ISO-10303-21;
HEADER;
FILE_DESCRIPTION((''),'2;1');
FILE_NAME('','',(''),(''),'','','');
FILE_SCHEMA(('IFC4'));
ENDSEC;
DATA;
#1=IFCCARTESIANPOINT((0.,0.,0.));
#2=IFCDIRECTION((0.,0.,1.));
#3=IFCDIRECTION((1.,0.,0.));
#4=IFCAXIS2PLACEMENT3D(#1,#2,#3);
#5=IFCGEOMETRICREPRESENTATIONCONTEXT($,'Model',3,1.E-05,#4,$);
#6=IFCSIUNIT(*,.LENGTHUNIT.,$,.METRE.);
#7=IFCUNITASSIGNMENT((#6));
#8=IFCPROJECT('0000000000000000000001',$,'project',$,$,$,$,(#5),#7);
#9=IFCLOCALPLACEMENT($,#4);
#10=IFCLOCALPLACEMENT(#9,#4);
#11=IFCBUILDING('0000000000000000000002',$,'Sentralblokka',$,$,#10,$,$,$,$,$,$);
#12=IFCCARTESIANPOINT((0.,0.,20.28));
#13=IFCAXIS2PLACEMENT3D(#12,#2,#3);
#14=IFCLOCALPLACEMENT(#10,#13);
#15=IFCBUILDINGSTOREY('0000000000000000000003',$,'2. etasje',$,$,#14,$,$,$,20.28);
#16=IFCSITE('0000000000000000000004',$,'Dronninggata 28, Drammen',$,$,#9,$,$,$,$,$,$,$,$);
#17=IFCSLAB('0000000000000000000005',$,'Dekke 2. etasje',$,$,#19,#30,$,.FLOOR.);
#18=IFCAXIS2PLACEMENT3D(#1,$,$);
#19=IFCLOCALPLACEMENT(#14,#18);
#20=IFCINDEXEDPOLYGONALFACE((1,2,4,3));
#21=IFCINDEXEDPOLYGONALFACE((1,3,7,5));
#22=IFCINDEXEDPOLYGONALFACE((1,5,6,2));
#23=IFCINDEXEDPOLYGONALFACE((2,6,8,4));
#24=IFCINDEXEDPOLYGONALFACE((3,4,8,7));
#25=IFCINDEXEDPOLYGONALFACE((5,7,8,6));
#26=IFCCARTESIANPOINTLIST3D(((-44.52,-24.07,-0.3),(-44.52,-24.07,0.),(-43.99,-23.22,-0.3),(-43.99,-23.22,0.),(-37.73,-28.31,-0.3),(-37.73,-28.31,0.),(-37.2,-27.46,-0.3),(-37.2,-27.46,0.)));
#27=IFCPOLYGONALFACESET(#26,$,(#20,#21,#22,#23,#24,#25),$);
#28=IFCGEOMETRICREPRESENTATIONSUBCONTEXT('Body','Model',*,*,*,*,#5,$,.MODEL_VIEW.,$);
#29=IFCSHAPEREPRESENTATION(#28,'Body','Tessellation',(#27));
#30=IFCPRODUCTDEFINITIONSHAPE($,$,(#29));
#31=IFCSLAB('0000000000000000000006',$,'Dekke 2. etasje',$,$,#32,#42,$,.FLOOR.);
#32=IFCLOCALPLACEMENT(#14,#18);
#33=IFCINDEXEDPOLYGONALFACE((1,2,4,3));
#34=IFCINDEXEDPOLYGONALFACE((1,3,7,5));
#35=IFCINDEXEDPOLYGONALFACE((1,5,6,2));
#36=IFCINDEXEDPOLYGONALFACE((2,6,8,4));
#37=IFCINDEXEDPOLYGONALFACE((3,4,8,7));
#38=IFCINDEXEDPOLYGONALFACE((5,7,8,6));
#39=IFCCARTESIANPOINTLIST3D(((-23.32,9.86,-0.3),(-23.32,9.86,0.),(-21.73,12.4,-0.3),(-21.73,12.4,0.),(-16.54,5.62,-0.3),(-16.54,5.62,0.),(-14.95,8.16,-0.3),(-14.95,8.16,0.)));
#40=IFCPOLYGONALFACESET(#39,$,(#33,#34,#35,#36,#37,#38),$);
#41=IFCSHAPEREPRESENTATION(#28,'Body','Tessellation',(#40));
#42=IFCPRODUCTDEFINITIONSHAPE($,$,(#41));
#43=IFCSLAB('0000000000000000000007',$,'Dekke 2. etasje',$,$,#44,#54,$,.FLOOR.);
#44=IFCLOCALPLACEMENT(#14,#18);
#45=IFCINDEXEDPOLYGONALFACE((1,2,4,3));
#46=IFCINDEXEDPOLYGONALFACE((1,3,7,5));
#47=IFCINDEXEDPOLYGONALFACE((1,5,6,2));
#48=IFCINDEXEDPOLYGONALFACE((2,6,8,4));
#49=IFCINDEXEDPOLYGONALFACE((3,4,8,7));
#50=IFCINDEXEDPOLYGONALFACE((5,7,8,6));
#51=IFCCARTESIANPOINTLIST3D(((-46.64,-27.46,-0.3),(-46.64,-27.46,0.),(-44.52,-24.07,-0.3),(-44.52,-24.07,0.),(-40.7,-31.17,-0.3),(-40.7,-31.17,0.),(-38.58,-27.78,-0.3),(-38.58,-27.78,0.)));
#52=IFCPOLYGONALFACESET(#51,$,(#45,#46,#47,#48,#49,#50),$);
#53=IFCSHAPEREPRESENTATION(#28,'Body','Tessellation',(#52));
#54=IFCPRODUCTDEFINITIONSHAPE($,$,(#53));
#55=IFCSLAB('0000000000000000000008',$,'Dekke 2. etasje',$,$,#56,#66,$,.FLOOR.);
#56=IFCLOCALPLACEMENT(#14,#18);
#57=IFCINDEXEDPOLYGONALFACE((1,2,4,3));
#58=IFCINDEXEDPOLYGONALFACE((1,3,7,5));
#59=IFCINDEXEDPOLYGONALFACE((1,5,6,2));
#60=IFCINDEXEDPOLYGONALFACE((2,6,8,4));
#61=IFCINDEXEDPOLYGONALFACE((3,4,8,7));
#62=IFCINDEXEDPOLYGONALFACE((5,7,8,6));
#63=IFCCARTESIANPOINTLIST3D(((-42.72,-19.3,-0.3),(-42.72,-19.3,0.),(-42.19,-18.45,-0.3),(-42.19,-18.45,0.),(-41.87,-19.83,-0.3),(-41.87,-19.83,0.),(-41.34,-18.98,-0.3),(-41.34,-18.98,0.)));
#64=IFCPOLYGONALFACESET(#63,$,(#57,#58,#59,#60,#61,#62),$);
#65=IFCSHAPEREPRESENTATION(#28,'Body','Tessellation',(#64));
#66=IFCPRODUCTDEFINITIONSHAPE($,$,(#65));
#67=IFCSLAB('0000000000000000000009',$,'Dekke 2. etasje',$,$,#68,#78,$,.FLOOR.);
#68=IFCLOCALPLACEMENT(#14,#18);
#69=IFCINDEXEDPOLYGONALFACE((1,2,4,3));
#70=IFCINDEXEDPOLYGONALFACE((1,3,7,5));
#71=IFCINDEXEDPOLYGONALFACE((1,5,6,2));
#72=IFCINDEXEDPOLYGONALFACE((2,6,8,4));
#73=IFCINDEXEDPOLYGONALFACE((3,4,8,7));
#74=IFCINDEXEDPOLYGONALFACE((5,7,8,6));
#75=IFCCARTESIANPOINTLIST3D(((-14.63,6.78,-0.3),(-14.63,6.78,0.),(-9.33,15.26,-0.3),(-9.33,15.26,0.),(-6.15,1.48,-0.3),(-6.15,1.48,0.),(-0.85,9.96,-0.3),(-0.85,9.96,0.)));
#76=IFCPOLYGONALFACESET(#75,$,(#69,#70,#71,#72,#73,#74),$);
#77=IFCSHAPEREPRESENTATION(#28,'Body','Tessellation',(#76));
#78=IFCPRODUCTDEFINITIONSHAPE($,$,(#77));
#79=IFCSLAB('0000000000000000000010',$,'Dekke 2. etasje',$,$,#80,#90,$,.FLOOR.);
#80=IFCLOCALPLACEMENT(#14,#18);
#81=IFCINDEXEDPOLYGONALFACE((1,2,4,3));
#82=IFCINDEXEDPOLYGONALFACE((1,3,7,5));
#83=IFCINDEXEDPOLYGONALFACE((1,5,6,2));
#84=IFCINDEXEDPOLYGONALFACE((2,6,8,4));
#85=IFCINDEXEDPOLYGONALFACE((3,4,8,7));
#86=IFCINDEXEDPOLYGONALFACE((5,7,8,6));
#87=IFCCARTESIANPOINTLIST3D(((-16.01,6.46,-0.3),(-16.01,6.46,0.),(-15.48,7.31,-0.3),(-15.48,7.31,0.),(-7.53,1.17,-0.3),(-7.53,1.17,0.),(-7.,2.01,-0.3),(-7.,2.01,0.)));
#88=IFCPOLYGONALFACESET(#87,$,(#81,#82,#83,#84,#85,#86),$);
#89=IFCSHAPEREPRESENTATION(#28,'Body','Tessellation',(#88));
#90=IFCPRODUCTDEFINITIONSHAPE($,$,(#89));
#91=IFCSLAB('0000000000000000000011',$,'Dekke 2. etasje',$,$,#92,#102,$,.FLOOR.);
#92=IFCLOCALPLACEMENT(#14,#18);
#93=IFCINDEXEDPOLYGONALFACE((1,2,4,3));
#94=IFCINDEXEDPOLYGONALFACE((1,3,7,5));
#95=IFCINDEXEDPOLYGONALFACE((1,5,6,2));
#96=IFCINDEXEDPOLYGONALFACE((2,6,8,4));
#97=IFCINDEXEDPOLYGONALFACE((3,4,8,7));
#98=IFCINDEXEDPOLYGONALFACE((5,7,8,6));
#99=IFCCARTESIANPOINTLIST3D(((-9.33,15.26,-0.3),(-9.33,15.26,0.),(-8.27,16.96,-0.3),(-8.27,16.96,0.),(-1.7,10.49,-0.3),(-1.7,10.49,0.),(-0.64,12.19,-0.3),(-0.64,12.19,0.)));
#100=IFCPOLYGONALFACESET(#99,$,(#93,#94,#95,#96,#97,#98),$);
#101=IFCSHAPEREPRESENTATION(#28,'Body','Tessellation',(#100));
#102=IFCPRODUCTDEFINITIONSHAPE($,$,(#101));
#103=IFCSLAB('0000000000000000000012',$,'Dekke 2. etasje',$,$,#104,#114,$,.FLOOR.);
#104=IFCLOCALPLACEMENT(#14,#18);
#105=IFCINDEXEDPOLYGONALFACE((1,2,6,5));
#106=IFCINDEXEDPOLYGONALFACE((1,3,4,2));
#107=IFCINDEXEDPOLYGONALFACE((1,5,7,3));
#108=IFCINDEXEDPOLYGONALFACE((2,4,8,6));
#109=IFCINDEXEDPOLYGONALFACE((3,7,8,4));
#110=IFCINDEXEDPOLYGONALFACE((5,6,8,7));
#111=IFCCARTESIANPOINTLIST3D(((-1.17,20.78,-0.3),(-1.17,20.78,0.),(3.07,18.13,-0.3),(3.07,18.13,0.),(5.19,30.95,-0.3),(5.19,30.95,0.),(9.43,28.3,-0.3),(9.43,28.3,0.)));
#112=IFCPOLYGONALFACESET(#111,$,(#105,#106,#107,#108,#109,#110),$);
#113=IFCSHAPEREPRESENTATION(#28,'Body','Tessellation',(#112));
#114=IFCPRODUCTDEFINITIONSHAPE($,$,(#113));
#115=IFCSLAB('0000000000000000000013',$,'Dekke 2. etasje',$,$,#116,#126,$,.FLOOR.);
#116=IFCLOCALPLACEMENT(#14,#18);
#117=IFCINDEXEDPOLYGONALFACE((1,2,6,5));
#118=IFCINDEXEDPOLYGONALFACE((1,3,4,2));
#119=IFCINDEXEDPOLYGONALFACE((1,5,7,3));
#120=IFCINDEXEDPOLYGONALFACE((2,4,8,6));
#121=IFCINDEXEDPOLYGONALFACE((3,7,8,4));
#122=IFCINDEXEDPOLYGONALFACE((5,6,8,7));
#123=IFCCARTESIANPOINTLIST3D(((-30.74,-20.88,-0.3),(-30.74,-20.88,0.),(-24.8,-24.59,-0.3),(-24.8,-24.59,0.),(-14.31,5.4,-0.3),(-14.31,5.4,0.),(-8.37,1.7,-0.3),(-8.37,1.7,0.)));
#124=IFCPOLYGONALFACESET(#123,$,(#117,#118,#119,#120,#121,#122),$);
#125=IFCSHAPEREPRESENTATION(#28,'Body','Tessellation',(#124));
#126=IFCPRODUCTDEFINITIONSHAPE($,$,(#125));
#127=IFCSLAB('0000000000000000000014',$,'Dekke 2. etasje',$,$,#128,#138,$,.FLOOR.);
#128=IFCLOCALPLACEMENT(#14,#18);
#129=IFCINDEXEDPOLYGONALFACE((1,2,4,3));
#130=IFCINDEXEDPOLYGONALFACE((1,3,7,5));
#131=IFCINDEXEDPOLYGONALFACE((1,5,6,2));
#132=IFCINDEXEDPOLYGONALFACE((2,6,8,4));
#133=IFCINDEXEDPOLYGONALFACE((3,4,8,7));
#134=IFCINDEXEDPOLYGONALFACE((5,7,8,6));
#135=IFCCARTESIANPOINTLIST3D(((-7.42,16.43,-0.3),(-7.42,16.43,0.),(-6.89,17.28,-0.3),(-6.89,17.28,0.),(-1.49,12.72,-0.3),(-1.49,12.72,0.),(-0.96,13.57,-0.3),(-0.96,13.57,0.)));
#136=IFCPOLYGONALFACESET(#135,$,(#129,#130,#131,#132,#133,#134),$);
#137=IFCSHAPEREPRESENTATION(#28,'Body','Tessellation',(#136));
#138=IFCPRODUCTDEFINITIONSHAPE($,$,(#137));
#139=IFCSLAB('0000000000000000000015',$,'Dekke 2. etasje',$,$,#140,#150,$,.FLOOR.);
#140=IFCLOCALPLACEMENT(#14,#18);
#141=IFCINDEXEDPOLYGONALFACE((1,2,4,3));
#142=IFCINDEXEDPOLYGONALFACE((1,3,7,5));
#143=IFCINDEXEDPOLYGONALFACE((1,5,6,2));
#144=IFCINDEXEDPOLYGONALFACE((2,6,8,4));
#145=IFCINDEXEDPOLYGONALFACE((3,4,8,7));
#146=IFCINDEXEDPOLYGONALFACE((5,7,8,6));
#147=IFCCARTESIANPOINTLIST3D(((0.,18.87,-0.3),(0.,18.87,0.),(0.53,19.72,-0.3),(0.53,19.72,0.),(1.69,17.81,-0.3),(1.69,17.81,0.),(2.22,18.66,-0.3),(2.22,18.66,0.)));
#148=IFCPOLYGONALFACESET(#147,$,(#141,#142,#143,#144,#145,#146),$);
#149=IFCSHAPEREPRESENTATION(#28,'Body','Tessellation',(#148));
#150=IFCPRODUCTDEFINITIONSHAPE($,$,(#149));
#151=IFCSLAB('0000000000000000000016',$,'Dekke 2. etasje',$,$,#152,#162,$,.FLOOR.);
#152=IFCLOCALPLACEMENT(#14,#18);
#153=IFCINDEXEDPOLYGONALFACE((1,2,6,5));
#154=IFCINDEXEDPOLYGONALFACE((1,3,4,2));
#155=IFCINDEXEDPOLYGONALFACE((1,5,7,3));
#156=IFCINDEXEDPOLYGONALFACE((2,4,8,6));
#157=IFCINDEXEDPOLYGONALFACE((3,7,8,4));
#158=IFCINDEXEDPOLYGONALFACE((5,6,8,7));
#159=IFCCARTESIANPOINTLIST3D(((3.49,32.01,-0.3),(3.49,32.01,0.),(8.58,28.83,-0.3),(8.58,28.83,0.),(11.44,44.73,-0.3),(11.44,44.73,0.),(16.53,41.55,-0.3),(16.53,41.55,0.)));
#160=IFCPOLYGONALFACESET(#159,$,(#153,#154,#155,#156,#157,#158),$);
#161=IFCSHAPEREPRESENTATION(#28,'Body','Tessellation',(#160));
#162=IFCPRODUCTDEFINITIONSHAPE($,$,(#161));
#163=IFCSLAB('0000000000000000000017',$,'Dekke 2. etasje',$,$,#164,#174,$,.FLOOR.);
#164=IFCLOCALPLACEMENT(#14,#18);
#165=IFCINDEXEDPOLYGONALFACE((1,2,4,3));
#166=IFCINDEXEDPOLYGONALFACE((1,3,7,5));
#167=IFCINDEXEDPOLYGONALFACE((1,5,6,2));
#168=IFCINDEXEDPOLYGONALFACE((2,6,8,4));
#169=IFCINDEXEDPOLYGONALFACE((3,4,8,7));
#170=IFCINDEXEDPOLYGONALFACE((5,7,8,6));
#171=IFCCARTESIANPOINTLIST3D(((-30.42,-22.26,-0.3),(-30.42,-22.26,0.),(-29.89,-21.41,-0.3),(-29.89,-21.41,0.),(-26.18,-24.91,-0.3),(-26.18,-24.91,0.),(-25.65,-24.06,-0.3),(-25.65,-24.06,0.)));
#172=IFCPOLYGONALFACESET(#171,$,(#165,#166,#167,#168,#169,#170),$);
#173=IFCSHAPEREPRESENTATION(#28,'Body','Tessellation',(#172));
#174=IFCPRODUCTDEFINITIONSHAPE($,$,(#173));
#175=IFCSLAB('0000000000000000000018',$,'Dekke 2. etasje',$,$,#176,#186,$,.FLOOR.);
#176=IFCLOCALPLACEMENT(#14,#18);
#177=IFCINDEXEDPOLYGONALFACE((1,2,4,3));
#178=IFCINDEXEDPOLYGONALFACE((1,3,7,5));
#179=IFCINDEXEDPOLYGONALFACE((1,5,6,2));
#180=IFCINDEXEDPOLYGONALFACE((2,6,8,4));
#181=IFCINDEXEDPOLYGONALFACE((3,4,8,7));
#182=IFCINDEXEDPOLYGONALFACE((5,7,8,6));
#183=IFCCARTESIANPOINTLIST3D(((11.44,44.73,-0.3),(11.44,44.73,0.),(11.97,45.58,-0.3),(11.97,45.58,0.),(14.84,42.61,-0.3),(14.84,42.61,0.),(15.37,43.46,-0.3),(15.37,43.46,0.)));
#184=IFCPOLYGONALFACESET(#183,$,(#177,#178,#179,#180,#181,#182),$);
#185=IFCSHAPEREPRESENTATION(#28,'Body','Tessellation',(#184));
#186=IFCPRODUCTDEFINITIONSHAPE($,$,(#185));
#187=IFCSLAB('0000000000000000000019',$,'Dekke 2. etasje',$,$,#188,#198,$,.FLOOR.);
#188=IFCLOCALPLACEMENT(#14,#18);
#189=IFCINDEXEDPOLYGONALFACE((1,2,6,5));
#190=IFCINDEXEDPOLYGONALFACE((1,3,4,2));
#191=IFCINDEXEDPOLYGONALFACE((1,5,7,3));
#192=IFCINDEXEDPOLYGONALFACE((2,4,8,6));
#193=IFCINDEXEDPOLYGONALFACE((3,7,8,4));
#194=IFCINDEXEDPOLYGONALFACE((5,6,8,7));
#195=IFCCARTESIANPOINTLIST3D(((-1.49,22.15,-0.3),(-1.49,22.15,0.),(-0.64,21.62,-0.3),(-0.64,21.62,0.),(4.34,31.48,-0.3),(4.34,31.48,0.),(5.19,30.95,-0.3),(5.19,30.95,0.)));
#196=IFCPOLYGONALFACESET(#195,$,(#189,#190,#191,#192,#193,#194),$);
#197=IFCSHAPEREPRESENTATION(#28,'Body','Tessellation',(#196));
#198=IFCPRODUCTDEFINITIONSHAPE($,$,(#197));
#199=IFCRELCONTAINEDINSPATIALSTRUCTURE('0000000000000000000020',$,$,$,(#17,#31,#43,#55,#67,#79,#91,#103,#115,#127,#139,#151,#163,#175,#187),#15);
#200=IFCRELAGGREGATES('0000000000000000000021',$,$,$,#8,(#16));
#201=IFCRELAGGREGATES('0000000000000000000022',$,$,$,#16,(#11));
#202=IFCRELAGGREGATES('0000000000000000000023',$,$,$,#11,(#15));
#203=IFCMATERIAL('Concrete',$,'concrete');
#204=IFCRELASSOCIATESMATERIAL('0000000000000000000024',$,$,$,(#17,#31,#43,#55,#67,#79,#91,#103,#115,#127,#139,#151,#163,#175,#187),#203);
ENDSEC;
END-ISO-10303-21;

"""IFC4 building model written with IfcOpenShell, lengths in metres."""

from ifc_helpers import new_model, si_unit, frame, origin_with_axes, place, context, subcontext, project, spatial, polyline, outline, extrude, material, element, save


model = new_model("IFC4")

# Units and contexts
model_context = context("Model", 3, precision=1e-05, world=origin_with_axes())
body_context = subcontext(model_context, "Body", "Model", "MODEL_VIEW")
ifc_project = project(units=[si_unit("LENGTHUNIT", "METRE")], contexts=[model_context])

# Site, building, storey
site_placement = place(None, origin_with_axes())
site = spatial("IfcSite", under=ifc_project, at=site_placement, Name="Dronninggata 28, Drammen")
building_placement = place(site_placement, origin_with_axes())
building = spatial("IfcBuilding", under=site, at=building_placement, Name="Sentralblokka")
storey_placement = place(building_placement, frame((0.0, 0.0, 20.28), z_axis=(0.0, 0.0, 1.0), x_axis=(1.0, 0.0, 0.0)))
storey = spatial("IfcBuildingStorey", under=building, at=storey_placement, Name="2. etasje", Elevation=20.28)

# Slabs
ifc_material = material(Name="Concrete", Category="concrete")
slab_1_placement = place(storey_placement, frame((0.0, 0.0, -20.28), z_axis=(0.0, 0.0, 1.0), x_axis=(1.0, 0.0, 0.0)))
element("IfcSlab", 1, at=slab_1_placement, inside=storey, material=ifc_material, Name="Dekke 2. etasje", PredefinedType="FLOOR", context=body_context, shape_type="SweptSolid", body=[
    extrude(outline(polyline([(-37.73, -28.31), (-37.2, -27.46), (-43.99, -23.22), (-44.52, -24.07), (-37.73, -28.31)])), frame((0.0, 0.0, 19.98)), (0.0, 0.0, 1.0), 0.3),
])
slab_2_placement = place(storey_placement, frame((0.0, 0.0, -20.28), z_axis=(0.0, 0.0, 1.0), x_axis=(1.0, 0.0, 0.0)))
element("IfcSlab", 2, at=slab_2_placement, inside=storey, material=ifc_material, Name="Dekke 2. etasje", PredefinedType="FLOOR", context=body_context, shape_type="SweptSolid", body=[
    extrude(outline(polyline([(-16.54, 5.62), (-14.95, 8.16), (-21.73, 12.4), (-23.32, 9.86), (-16.54, 5.62)])), frame((0.0, 0.0, 19.98)), (0.0, 0.0, 1.0), 0.3),
])
slab_3_placement = place(storey_placement, frame((0.0, 0.0, -20.28), z_axis=(0.0, 0.0, 1.0), x_axis=(1.0, 0.0, 0.0)))
element("IfcSlab", 3, at=slab_3_placement, inside=storey, material=ifc_material, Name="Dekke 2. etasje", PredefinedType="FLOOR", context=body_context, shape_type="SweptSolid", body=[
    extrude(outline(polyline([(-40.7, -31.17), (-38.58, -27.78), (-44.52, -24.07), (-46.64, -27.46), (-40.7, -31.17)])), frame((0.0, 0.0, 19.98)), (0.0, 0.0, 1.0), 0.3),
])
slab_4_placement = place(storey_placement, frame((0.0, 0.0, -20.28), z_axis=(0.0, 0.0, 1.0), x_axis=(1.0, 0.0, 0.0)))
element("IfcSlab", 4, at=slab_4_placement, inside=storey, material=ifc_material, Name="Dekke 2. etasje", PredefinedType="FLOOR", context=body_context, shape_type="SweptSolid", body=[
    extrude(outline(polyline([(-41.87, -19.83), (-41.34, -18.98), (-42.19, -18.45), (-42.72, -19.3), (-41.87, -19.83)])), frame((0.0, 0.0, 19.98)), (0.0, 0.0, 1.0), 0.3),
])
slab_5_placement = place(storey_placement, frame((0.0, 0.0, -20.28), z_axis=(0.0, 0.0, 1.0), x_axis=(1.0, 0.0, 0.0)))
element("IfcSlab", 5, at=slab_5_placement, inside=storey, material=ifc_material, Name="Dekke 2. etasje", PredefinedType="FLOOR", context=body_context, shape_type="SweptSolid", body=[
    extrude(outline(polyline([(-6.15, 1.48), (-0.85, 9.96), (-9.33, 15.26), (-14.63, 6.78), (-6.15, 1.48)])), frame((0.0, 0.0, 19.98)), (0.0, 0.0, 1.0), 0.3),
])
slab_6_placement = place(storey_placement, frame((0.0, 0.0, -20.28), z_axis=(0.0, 0.0, 1.0), x_axis=(1.0, 0.0, 0.0)))
element("IfcSlab", 6, at=slab_6_placement, inside=storey, material=ifc_material, Name="Dekke 2. etasje", PredefinedType="FLOOR", context=body_context, shape_type="SweptSolid", body=[
    extrude(outline(polyline([(-7.53, 1.17), (-7.0, 2.01), (-15.48, 7.31), (-16.01, 6.46), (-7.53, 1.17)])), frame((0.0, 0.0, 19.98)), (0.0, 0.0, 1.0), 0.3),
])
slab_7_placement = place(storey_placement, frame((0.0, 0.0, -20.28), z_axis=(0.0, 0.0, 1.0), x_axis=(1.0, 0.0, 0.0)))
element("IfcSlab", 7, at=slab_7_placement, inside=storey, material=ifc_material, Name="Dekke 2. etasje", PredefinedType="FLOOR", context=body_context, shape_type="SweptSolid", body=[
    extrude(outline(polyline([(-1.7, 10.49), (-0.64, 12.19), (-8.27, 16.96), (-9.33, 15.26), (-1.7, 10.49)])), frame((0.0, 0.0, 19.98)), (0.0, 0.0, 1.0), 0.3),
])
slab_8_placement = place(storey_placement, frame((0.0, 0.0, -20.28), z_axis=(0.0, 0.0, 1.0), x_axis=(1.0, 0.0, 0.0)))
element("IfcSlab", 8, at=slab_8_placement, inside=storey, material=ifc_material, Name="Dekke 2. etasje", PredefinedType="FLOOR", context=body_context, shape_type="SweptSolid", body=[
    extrude(outline(polyline([(3.07, 18.13), (9.43, 28.3), (5.19, 30.95), (-1.17, 20.78), (3.07, 18.13)])), frame((0.0, 0.0, 19.98)), (0.0, 0.0, 1.0), 0.3),
])
slab_9_placement = place(storey_placement, frame((0.0, 0.0, -20.28), z_axis=(0.0, 0.0, 1.0), x_axis=(1.0, 0.0, 0.0)))
element("IfcSlab", 9, at=slab_9_placement, inside=storey, material=ifc_material, Name="Dekke 2. etasje", PredefinedType="FLOOR", context=body_context, shape_type="SweptSolid", body=[
    extrude(outline(polyline([(-24.8, -24.59), (-8.37, 1.7), (-14.31, 5.4), (-30.74, -20.88), (-24.8, -24.59)])), frame((0.0, 0.0, 19.98)), (0.0, 0.0, 1.0), 0.3),
])
slab_10_placement = place(storey_placement, frame((0.0, 0.0, -20.28), z_axis=(0.0, 0.0, 1.0), x_axis=(1.0, 0.0, 0.0)))
element("IfcSlab", 10, at=slab_10_placement, inside=storey, material=ifc_material, Name="Dekke 2. etasje", PredefinedType="FLOOR", context=body_context, shape_type="SweptSolid", body=[
    extrude(outline(polyline([(-1.49, 12.72), (-0.96, 13.57), (-6.89, 17.28), (-7.42, 16.43), (-1.49, 12.72)])), frame((0.0, 0.0, 19.98)), (0.0, 0.0, 1.0), 0.3),
])
slab_11_placement = place(storey_placement, frame((0.0, 0.0, -20.28), z_axis=(0.0, 0.0, 1.0), x_axis=(1.0, 0.0, 0.0)))
element("IfcSlab", 11, at=slab_11_placement, inside=storey, material=ifc_material, Name="Dekke 2. etasje", PredefinedType="FLOOR", context=body_context, shape_type="SweptSolid", body=[
    extrude(outline(polyline([(1.69, 17.81), (2.22, 18.66), (0.53, 19.72), (0.0, 18.87), (1.69, 17.81)])), frame((0.0, 0.0, 19.98)), (0.0, 0.0, 1.0), 0.3),
])
slab_12_placement = place(storey_placement, frame((0.0, 0.0, -20.28), z_axis=(0.0, 0.0, 1.0), x_axis=(1.0, 0.0, 0.0)))
element("IfcSlab", 12, at=slab_12_placement, inside=storey, material=ifc_material, Name="Dekke 2. etasje", PredefinedType="FLOOR", context=body_context, shape_type="SweptSolid", body=[
    extrude(outline(polyline([(8.58, 28.83), (16.53, 41.55), (11.44, 44.73), (3.49, 32.01), (8.58, 28.83)])), frame((0.0, 0.0, 19.98)), (0.0, 0.0, 1.0), 0.3),
])
slab_13_placement = place(storey_placement, frame((0.0, 0.0, -20.28), z_axis=(0.0, 0.0, 1.0), x_axis=(1.0, 0.0, 0.0)))
element("IfcSlab", 13, at=slab_13_placement, inside=storey, material=ifc_material, Name="Dekke 2. etasje", PredefinedType="FLOOR", context=body_context, shape_type="SweptSolid", body=[
    extrude(outline(polyline([(-26.18, -24.91), (-25.65, -24.06), (-29.89, -21.41), (-30.42, -22.26), (-26.18, -24.91)])), frame((0.0, 0.0, 19.98)), (0.0, 0.0, 1.0), 0.3),
])
slab_14_placement = place(storey_placement, frame((0.0, 0.0, -20.28), z_axis=(0.0, 0.0, 1.0), x_axis=(1.0, 0.0, 0.0)))
element("IfcSlab", 14, at=slab_14_placement, inside=storey, material=ifc_material, Name="Dekke 2. etasje", PredefinedType="FLOOR", context=body_context, shape_type="SweptSolid", body=[
    extrude(outline(polyline([(14.84, 42.61), (15.37, 43.46), (11.97, 45.58), (11.44, 44.73), (14.84, 42.61)])), frame((0.0, 0.0, 19.98)), (0.0, 0.0, 1.0), 0.3),
])
slab_15_placement = place(storey_placement, frame((0.0, 0.0, -20.28), z_axis=(0.0, 0.0, 1.0), x_axis=(1.0, 0.0, 0.0)))
element("IfcSlab", 15, at=slab_15_placement, inside=storey, material=ifc_material, Name="Dekke 2. etasje", PredefinedType="FLOOR", context=body_context, shape_type="SweptSolid", body=[
    extrude(outline(polyline([(-0.64, 21.62), (5.19, 30.95), (4.34, 31.48), (-1.49, 22.15), (-0.64, 21.62)])), frame((0.0, 0.0, 19.98)), (0.0, 0.0, 1.0), 0.3),
])

save(model, "model.ifc")
